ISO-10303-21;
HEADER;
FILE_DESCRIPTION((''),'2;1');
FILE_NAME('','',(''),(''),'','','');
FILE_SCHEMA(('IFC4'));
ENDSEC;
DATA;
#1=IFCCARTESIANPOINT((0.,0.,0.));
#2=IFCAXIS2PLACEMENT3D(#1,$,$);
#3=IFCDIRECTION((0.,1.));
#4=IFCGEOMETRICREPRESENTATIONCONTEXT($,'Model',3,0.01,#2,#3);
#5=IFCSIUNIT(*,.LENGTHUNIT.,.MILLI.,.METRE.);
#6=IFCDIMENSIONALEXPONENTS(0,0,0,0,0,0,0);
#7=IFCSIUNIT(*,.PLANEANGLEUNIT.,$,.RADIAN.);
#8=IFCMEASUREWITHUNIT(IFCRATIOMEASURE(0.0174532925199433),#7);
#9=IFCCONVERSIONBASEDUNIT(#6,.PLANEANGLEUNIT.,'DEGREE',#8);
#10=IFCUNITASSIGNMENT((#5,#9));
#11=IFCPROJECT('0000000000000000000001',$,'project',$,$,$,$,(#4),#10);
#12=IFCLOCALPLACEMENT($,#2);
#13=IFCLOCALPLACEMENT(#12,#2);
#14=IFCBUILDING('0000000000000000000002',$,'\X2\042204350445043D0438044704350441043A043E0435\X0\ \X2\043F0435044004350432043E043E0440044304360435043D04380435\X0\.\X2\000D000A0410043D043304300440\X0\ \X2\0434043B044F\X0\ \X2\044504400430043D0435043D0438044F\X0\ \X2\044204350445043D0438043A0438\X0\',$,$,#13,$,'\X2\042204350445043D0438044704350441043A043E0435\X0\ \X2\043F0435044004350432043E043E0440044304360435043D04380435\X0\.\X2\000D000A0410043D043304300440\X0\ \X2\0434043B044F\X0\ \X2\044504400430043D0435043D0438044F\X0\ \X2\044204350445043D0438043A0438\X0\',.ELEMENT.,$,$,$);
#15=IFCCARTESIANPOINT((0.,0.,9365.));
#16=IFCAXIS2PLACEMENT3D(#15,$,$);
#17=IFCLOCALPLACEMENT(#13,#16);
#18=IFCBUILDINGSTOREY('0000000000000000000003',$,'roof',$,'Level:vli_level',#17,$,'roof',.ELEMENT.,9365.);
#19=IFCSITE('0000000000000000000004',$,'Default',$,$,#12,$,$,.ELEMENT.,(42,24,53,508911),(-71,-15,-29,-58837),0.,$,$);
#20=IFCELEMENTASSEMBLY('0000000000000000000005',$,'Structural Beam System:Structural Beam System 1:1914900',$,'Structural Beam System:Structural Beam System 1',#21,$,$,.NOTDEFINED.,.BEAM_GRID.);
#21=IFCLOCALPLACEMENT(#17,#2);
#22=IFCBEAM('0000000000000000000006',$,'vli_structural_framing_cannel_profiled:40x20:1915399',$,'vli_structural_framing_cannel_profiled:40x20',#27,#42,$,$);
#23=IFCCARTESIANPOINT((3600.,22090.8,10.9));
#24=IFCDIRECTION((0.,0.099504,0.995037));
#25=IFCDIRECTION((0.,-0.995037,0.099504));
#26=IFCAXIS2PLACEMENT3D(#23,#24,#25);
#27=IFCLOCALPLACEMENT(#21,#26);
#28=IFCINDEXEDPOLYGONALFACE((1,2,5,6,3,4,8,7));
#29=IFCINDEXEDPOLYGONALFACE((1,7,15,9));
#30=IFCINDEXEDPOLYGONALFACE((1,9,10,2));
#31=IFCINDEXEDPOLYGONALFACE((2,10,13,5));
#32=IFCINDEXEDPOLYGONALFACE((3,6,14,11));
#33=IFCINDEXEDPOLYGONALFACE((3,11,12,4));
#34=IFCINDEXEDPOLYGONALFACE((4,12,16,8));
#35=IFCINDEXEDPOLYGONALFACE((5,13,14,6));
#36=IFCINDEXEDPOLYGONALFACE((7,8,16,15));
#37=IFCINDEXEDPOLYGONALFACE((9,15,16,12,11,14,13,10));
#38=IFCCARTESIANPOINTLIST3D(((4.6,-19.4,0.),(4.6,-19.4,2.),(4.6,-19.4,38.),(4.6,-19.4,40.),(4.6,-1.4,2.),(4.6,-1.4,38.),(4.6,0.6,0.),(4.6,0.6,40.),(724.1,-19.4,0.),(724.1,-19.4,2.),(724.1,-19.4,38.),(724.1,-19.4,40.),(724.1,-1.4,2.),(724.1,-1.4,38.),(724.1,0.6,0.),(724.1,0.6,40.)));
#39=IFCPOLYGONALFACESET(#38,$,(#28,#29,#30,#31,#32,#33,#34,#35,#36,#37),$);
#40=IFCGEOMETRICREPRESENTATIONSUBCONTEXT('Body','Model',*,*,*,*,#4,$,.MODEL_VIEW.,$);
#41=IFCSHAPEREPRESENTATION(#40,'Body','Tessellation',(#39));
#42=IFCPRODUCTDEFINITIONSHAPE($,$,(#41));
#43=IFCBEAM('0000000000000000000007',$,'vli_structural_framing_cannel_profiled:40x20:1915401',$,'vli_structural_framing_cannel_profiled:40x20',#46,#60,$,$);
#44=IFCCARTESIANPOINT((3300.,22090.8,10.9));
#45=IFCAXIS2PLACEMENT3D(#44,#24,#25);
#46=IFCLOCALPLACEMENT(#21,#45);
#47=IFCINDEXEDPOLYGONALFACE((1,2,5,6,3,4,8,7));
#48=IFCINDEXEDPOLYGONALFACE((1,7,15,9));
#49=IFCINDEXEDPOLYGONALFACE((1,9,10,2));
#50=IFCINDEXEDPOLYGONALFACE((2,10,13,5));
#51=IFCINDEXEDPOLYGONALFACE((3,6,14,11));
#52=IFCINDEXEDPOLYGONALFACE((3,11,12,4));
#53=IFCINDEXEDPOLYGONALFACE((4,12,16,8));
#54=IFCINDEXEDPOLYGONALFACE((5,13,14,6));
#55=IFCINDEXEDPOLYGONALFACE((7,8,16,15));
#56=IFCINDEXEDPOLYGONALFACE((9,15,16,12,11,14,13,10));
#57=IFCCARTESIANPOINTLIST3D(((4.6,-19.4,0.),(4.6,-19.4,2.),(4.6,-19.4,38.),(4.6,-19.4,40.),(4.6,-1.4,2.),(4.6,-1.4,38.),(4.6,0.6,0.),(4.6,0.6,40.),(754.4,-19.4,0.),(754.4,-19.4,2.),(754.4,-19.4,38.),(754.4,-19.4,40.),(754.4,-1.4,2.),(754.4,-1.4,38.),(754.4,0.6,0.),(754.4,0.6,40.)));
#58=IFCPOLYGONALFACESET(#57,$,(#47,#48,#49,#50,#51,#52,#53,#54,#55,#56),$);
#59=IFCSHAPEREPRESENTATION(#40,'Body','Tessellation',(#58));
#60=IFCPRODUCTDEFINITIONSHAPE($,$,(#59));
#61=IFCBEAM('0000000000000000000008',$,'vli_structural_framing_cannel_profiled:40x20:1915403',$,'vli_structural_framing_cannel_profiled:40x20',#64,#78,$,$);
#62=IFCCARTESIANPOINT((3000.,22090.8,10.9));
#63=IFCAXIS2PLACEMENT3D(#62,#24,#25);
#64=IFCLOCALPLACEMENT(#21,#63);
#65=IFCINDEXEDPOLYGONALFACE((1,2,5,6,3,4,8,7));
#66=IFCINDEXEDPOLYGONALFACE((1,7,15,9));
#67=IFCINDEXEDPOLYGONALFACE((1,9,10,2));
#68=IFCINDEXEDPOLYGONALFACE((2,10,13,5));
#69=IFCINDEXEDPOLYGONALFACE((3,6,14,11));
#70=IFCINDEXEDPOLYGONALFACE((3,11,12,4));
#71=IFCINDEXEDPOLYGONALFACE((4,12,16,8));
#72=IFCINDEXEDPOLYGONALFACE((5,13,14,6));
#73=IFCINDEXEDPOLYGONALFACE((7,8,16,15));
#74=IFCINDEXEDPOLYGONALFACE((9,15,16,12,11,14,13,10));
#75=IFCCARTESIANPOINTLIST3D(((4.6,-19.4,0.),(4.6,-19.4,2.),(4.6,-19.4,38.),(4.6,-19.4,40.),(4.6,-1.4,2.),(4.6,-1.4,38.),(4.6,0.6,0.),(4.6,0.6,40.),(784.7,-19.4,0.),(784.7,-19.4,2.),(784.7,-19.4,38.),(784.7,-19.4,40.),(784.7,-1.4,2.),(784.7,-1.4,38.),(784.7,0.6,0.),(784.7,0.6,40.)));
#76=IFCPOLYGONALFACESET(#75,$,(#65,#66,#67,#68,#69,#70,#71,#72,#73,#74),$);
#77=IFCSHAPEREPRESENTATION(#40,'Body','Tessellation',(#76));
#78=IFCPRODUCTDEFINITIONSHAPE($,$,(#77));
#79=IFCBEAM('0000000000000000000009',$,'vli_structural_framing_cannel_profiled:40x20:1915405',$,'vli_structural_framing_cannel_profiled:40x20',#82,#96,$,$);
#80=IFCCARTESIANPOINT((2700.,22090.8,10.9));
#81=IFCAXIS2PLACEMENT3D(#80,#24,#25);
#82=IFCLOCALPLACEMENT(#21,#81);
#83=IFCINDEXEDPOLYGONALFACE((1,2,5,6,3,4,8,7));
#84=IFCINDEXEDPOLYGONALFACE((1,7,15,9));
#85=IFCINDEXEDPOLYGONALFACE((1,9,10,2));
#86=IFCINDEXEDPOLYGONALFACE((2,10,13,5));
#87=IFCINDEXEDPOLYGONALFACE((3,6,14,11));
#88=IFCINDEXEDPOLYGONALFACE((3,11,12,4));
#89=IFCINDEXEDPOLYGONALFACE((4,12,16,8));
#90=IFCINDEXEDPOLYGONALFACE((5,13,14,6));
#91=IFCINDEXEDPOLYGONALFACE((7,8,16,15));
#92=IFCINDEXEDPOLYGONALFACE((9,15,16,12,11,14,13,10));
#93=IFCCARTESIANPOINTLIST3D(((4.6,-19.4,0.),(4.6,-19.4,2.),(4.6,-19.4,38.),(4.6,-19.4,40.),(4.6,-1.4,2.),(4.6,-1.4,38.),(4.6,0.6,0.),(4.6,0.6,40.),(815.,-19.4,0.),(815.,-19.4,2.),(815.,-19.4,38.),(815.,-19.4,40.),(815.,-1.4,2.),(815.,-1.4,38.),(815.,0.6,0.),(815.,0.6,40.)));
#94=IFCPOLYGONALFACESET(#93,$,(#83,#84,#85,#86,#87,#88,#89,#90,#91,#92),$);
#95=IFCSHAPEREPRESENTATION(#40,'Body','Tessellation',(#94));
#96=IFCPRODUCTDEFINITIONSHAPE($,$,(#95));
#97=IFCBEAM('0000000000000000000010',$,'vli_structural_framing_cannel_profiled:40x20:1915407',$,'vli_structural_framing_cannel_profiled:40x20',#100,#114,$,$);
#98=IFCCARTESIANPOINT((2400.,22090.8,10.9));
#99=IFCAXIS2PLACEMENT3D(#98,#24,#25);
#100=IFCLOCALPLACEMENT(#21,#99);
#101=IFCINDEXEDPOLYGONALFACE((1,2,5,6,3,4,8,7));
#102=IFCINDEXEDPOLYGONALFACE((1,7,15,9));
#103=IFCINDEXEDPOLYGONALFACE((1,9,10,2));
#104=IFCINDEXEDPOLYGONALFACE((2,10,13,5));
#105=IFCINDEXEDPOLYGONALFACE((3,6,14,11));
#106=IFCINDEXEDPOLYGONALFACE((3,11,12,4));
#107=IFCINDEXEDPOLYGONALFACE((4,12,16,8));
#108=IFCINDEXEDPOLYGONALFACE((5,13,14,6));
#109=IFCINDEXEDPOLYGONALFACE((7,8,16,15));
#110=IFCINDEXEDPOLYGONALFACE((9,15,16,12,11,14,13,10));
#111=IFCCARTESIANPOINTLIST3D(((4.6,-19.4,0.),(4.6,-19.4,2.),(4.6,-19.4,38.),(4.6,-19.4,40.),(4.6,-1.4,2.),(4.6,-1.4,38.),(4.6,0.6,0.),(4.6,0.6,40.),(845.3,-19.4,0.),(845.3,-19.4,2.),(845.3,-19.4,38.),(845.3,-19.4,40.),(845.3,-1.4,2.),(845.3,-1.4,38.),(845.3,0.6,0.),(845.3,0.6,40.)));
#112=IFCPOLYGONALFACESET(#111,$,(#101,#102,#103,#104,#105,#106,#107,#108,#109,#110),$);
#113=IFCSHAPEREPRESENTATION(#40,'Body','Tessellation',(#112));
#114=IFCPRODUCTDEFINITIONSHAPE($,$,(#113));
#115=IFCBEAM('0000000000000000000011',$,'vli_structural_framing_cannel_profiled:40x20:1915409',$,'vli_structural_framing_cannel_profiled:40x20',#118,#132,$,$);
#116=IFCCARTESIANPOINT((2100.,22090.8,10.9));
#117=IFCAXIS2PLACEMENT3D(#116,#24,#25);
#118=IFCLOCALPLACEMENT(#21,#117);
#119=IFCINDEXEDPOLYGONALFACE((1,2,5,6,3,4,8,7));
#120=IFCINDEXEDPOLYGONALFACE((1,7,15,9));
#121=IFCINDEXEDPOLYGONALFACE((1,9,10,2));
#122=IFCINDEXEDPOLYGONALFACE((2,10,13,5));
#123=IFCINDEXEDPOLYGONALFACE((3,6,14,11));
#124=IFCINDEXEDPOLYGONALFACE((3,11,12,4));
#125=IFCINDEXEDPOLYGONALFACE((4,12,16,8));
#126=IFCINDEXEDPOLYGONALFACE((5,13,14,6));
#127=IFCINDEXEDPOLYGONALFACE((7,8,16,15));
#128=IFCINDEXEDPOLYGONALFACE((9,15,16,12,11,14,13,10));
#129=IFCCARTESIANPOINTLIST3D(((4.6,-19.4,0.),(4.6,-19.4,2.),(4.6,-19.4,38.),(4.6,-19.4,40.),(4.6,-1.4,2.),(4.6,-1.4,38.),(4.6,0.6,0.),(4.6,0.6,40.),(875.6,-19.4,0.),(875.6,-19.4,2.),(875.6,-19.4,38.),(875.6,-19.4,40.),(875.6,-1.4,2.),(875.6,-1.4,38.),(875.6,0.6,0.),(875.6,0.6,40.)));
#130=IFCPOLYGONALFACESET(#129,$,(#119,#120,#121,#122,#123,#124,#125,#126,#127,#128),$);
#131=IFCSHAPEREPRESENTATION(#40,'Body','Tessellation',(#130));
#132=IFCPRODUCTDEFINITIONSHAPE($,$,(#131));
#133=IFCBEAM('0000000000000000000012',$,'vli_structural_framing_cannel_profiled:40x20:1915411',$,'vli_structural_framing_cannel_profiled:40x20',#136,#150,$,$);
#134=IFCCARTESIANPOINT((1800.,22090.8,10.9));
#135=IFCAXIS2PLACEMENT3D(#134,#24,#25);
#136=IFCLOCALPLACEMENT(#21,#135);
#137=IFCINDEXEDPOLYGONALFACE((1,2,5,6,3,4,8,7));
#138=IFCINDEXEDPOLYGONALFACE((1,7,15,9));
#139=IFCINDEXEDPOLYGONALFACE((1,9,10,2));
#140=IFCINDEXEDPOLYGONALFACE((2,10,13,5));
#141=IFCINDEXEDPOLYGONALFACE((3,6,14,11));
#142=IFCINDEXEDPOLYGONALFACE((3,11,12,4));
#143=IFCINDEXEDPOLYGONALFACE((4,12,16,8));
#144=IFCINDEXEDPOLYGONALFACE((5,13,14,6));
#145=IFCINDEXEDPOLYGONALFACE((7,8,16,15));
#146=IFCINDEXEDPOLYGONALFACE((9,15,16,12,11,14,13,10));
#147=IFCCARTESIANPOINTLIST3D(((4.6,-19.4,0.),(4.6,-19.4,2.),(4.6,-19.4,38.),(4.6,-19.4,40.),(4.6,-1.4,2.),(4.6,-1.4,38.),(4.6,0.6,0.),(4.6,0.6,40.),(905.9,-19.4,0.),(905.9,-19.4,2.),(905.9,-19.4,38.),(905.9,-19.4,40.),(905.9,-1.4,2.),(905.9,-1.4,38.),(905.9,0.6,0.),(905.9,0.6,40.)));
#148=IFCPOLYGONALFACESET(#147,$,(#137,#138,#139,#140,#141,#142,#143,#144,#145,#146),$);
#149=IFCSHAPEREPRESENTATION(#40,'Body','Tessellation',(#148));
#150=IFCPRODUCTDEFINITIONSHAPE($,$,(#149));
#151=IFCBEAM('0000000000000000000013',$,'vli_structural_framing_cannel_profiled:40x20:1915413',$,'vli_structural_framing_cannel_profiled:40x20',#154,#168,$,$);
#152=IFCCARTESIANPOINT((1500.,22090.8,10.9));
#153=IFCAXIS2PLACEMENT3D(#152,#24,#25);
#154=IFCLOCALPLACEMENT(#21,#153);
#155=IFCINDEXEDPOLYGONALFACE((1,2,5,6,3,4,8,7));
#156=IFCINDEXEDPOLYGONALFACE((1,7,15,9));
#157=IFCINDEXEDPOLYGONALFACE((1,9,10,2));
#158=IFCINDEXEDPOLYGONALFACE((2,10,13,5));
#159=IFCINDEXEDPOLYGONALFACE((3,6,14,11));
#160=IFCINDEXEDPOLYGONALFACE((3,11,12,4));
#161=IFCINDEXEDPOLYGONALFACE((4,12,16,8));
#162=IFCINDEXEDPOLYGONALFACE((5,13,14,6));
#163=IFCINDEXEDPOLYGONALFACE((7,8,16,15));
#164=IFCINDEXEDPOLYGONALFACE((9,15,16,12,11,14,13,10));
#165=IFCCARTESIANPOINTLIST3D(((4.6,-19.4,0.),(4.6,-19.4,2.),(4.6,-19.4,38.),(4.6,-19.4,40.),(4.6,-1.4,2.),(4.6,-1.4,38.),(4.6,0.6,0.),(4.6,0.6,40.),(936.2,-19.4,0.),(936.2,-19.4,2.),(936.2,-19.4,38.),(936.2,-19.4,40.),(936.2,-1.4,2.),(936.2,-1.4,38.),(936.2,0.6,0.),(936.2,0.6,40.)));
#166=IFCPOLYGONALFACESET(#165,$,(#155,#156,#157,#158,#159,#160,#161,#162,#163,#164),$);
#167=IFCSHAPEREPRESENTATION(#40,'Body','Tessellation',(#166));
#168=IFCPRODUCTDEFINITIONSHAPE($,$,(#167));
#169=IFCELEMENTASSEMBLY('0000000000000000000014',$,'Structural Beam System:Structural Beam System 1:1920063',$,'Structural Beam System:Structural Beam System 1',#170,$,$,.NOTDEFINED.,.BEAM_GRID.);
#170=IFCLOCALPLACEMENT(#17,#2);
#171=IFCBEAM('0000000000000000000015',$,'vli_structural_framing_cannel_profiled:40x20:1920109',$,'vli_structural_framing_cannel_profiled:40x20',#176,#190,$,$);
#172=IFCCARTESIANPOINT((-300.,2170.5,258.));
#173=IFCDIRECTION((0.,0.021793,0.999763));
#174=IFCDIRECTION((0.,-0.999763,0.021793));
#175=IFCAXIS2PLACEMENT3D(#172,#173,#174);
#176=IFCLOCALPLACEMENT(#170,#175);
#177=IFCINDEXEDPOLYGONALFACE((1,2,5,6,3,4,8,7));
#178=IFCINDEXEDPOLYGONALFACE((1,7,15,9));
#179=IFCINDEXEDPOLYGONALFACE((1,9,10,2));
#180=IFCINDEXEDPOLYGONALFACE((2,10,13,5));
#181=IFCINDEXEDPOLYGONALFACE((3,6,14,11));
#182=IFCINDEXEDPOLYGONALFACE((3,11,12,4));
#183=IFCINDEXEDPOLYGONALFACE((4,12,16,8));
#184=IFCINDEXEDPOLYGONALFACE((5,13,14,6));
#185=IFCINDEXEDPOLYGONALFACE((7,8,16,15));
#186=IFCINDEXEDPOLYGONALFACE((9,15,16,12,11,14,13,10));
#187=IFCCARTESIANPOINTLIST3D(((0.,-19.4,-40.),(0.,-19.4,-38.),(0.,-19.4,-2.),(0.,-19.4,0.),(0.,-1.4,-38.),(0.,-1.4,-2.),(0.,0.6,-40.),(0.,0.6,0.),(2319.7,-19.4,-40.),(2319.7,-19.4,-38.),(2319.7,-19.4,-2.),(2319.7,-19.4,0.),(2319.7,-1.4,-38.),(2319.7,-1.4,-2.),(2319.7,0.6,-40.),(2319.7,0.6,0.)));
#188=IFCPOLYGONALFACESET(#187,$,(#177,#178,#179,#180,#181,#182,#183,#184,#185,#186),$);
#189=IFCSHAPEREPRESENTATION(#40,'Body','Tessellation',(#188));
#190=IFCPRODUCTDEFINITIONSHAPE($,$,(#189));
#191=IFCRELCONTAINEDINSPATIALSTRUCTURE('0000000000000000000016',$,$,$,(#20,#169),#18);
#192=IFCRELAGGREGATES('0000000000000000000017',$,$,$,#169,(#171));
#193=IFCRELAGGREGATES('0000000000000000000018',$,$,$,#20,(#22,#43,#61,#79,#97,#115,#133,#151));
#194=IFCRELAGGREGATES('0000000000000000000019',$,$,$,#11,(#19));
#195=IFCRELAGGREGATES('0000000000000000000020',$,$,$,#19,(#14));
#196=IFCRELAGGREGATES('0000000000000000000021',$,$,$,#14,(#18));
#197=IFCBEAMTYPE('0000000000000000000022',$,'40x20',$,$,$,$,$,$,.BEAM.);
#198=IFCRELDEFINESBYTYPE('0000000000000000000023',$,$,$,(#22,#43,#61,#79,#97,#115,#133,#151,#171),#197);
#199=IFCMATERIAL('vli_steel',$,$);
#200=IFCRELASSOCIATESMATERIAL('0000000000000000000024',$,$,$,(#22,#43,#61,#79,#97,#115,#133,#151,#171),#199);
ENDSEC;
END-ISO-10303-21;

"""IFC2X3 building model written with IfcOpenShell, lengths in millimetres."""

from ifc_helpers import new_model, entity, si_unit, converted_unit, direction, frame, origin, place, context, subcontext, project, spatial, polyline, outline, extrude, material, type_object, element, aggregate, save


model = new_model("IFC2X3")

# Units and contexts
model_context = context("Model", 3, precision=0.01, world=origin(), true_north=direction((0.0, 1.0)))
body_context = subcontext(model_context, "Body", "Model", "MODEL_VIEW")
ifc_project = project(units=[si_unit("LENGTHUNIT", "METRE", prefix="MILLI"), converted_unit("PLANEANGLEUNIT", "DEGREE", entity("IfcRatioMeasure", 0.0174532925199433), si_unit("PLANEANGLEUNIT", "RADIAN"), dimensions=[0, 0, 0, 0, 0, 0, 0])], contexts=[model_context])

# Site, building, storey
site_placement = place(None, origin())
site = spatial("IfcSite", under=ifc_project, at=site_placement, Name="Default", CompositionType="ELEMENT", RefLatitude=(42, 24, 53, 508911), RefLongitude=(-71, -15, -29, -58837), RefElevation=0.0)
building_placement = place(site_placement, origin())
building = spatial("IfcBuilding", under=site, at=building_placement, Name="Техническое перевооружение.\r\nАнгар для хранения техники", LongName="Техническое перевооружение.\r\nАнгар для хранения техники", CompositionType="ELEMENT")
storey_placement = place(building_placement, frame((0.0, 0.0, 9365.0)))
storey = spatial("IfcBuildingStorey", under=building, at=storey_placement, Name="roof", ObjectType="Level:vli_level", LongName="roof", CompositionType="ELEMENT", Elevation=9365.0)

# Element assemblies, beams
assembly_1_placement = place(storey_placement, origin())
assembly_1 = element("IfcElementAssembly", 1, at=assembly_1_placement, inside=storey, Name="Structural Beam System:Structural Beam System 1:1914900", ObjectType="Structural Beam System:Structural Beam System 1", AssemblyPlace="NOTDEFINED", PredefinedType="BEAM_GRID")
ifc_material = material(Name="vli_steel")
beam_type = type_object("IfcBeamType", Name="40x20", PredefinedType="BEAM")
beam_1_placement = place(assembly_1_placement, frame((3600.0, 22090.8, 10.9), z_axis=(0.0, 0.099504, 0.995037), x_axis=(0.0, -0.995037, 0.099504)))
beam_1 = element("IfcBeam", 2, at=beam_1_placement, type_object=beam_type, material=ifc_material, Name="vli_structural_framing_cannel_profiled:40x20:1915399", ObjectType="vli_structural_framing_cannel_profiled:40x20", context=body_context, shape_type="SweptSolid", body=[
    extrude(outline(polyline([(-20.0, -9.5), (-18.0, -9.5), (-18.0, 8.5), (18.0, 8.5), (18.0, -9.5), (20.0, -9.5), (20.0, 10.5), (-20.0, 10.5), (-20.0, -9.5)])), frame((4.6, -9.9, 20.0), z_axis=(1.0, 0.0, 0.0), x_axis=(0.0, 0.0, -1.0)), (0.0, 0.0, 1.0), 719.5),
])
beam_2_placement = place(assembly_1_placement, frame((3300.0, 22090.8, 10.9), z_axis=(0.0, 0.099504, 0.995037), x_axis=(0.0, -0.995037, 0.099504)))
beam_2 = element("IfcBeam", 3, at=beam_2_placement, type_object=beam_type, material=ifc_material, Name="vli_structural_framing_cannel_profiled:40x20:1915401", ObjectType="vli_structural_framing_cannel_profiled:40x20", context=body_context, shape_type="SweptSolid", body=[
    extrude(outline(polyline([(-20.0, -9.5), (-18.0, -9.5), (-18.0, 8.5), (18.0, 8.5), (18.0, -9.5), (20.0, -9.5), (20.0, 10.5), (-20.0, 10.5), (-20.0, -9.5)])), frame((4.6, -9.9, 20.0), z_axis=(1.0, 0.0, 0.0), x_axis=(0.0, 0.0, -1.0)), (0.0, 0.0, 1.0), 749.8),
])
beam_3_placement = place(assembly_1_placement, frame((3000.0, 22090.8, 10.9), z_axis=(0.0, 0.099504, 0.995037), x_axis=(0.0, -0.995037, 0.099504)))
beam_3 = element("IfcBeam", 4, at=beam_3_placement, type_object=beam_type, material=ifc_material, Name="vli_structural_framing_cannel_profiled:40x20:1915403", ObjectType="vli_structural_framing_cannel_profiled:40x20", context=body_context, shape_type="SweptSolid", body=[
    extrude(outline(polyline([(-20.0, -9.5), (-18.0, -9.5), (-18.0, 8.5), (18.0, 8.5), (18.0, -9.5), (20.0, -9.5), (20.0, 10.5), (-20.0, 10.5), (-20.0, -9.5)])), frame((4.6, -9.9, 20.0), z_axis=(1.0, 0.0, 0.0), x_axis=(0.0, 0.0, -1.0)), (0.0, 0.0, 1.0), 780.2),
])
beam_4_placement = place(assembly_1_placement, frame((2700.0, 22090.8, 10.9), z_axis=(0.0, 0.099504, 0.995037), x_axis=(0.0, -0.995037, 0.099504)))
beam_4 = element("IfcBeam", 5, at=beam_4_placement, type_object=beam_type, material=ifc_material, Name="vli_structural_framing_cannel_profiled:40x20:1915405", ObjectType="vli_structural_framing_cannel_profiled:40x20", context=body_context, shape_type="SweptSolid", body=[
    extrude(outline(polyline([(-20.0, -9.5), (-18.0, -9.5), (-18.0, 8.5), (18.0, 8.5), (18.0, -9.5), (20.0, -9.5), (20.0, 10.5), (-20.0, 10.5), (-20.0, -9.5)])), frame((4.6, -9.9, 20.0), z_axis=(1.0, 0.0, 0.0), x_axis=(0.0, 0.0, -1.0)), (0.0, 0.0, 1.0), 810.5),
])
beam_5_placement = place(assembly_1_placement, frame((2400.0, 22090.8, 10.9), z_axis=(0.0, 0.099504, 0.995037), x_axis=(0.0, -0.995037, 0.099504)))
beam_5 = element("IfcBeam", 6, at=beam_5_placement, type_object=beam_type, material=ifc_material, Name="vli_structural_framing_cannel_profiled:40x20:1915407", ObjectType="vli_structural_framing_cannel_profiled:40x20", context=body_context, shape_type="SweptSolid", body=[
    extrude(outline(polyline([(-20.0, -9.5), (-18.0, -9.5), (-18.0, 8.5), (18.0, 8.5), (18.0, -9.5), (20.0, -9.5), (20.0, 10.5), (-20.0, 10.5), (-20.0, -9.5)])), frame((4.6, -9.9, 20.0), z_axis=(1.0, 0.0, 0.0), x_axis=(0.0, 0.0, -1.0)), (0.0, 0.0, 1.0), 840.8),
])
beam_6_placement = place(assembly_1_placement, frame((2100.0, 22090.8, 10.9), z_axis=(0.0, 0.099504, 0.995037), x_axis=(0.0, -0.995037, 0.099504)))
beam_6 = element("IfcBeam", 7, at=beam_6_placement, type_object=beam_type, material=ifc_material, Name="vli_structural_framing_cannel_profiled:40x20:1915409", ObjectType="vli_structural_framing_cannel_profiled:40x20", context=body_context, shape_type="SweptSolid", body=[
    extrude(outline(polyline([(-20.0, -9.5), (-18.0, -9.5), (-18.0, 8.5), (18.0, 8.5), (18.0, -9.5), (20.0, -9.5), (20.0, 10.5), (-20.0, 10.5), (-20.0, -9.5)])), frame((4.6, -9.9, 20.0), z_axis=(1.0, 0.0, 0.0), x_axis=(0.0, 0.0, -1.0)), (0.0, 0.0, 1.0), 871.1),
])
beam_7_placement = place(assembly_1_placement, frame((1800.0, 22090.8, 10.9), z_axis=(0.0, 0.099504, 0.995037), x_axis=(0.0, -0.995037, 0.099504)))
beam_7 = element("IfcBeam", 8, at=beam_7_placement, type_object=beam_type, material=ifc_material, Name="vli_structural_framing_cannel_profiled:40x20:1915411", ObjectType="vli_structural_framing_cannel_profiled:40x20", context=body_context, shape_type="SweptSolid", body=[
    extrude(outline(polyline([(-20.0, -9.5), (-18.0, -9.5), (-18.0, 8.5), (18.0, 8.5), (18.0, -9.5), (20.0, -9.5), (20.0, 10.5), (-20.0, 10.5), (-20.0, -9.5)])), frame((4.6, -9.9, 20.0), z_axis=(1.0, 0.0, 0.0), x_axis=(0.0, 0.0, -1.0)), (0.0, 0.0, 1.0), 901.4),
])
beam_8_placement = place(assembly_1_placement, frame((1500.0, 22090.8, 10.9), z_axis=(0.0, 0.099504, 0.995037), x_axis=(0.0, -0.995037, 0.099504)))
beam_8 = element("IfcBeam", 9, at=beam_8_placement, type_object=beam_type, material=ifc_material, Name="vli_structural_framing_cannel_profiled:40x20:1915413", ObjectType="vli_structural_framing_cannel_profiled:40x20", context=body_context, shape_type="SweptSolid", body=[
    extrude(outline(polyline([(-20.0, -9.5), (-18.0, -9.5), (-18.0, 8.5), (18.0, 8.5), (18.0, -9.5), (20.0, -9.5), (20.0, 10.5), (-20.0, 10.5), (-20.0, -9.5)])), frame((4.6, -9.9, 20.0), z_axis=(1.0, 0.0, 0.0), x_axis=(0.0, 0.0, -1.0)), (0.0, 0.0, 1.0), 931.7),
])
assembly_2_placement = place(storey_placement, origin())
assembly_2 = element("IfcElementAssembly", 10, at=assembly_2_placement, inside=storey, Name="Structural Beam System:Structural Beam System 1:1920063", ObjectType="Structural Beam System:Structural Beam System 1", AssemblyPlace="NOTDEFINED", PredefinedType="BEAM_GRID")
beam_9_placement = place(assembly_2_placement, frame((-300.0, 2170.5, 258.0), z_axis=(0.0, 0.021793, 0.999763), x_axis=(0.0, -0.999763, 0.021793)))
beam_9 = element("IfcBeam", 11, at=beam_9_placement, type_object=beam_type, material=ifc_material, Name="vli_structural_framing_cannel_profiled:40x20:1920109", ObjectType="vli_structural_framing_cannel_profiled:40x20", context=body_context, shape_type="SweptSolid", body=[
    extrude(outline(polyline([(-20.0, -9.5), (-18.0, -9.5), (-18.0, 8.5), (18.0, 8.5), (18.0, -9.5), (20.0, -9.5), (20.0, 10.5), (-20.0, 10.5), (-20.0, -9.5)])), frame((0.0, -9.9, -20.0), z_axis=(1.0, 0.0, 0.0), x_axis=(0.0, 0.0, -1.0)), (0.0, 0.0, 1.0), 2319.7),
])
aggregate(assembly_2, [beam_9])

aggregate(assembly_1, [beam_1, beam_2, beam_3, beam_4, beam_5, beam_6, beam_7, beam_8])

save(model, "model.ifc")
